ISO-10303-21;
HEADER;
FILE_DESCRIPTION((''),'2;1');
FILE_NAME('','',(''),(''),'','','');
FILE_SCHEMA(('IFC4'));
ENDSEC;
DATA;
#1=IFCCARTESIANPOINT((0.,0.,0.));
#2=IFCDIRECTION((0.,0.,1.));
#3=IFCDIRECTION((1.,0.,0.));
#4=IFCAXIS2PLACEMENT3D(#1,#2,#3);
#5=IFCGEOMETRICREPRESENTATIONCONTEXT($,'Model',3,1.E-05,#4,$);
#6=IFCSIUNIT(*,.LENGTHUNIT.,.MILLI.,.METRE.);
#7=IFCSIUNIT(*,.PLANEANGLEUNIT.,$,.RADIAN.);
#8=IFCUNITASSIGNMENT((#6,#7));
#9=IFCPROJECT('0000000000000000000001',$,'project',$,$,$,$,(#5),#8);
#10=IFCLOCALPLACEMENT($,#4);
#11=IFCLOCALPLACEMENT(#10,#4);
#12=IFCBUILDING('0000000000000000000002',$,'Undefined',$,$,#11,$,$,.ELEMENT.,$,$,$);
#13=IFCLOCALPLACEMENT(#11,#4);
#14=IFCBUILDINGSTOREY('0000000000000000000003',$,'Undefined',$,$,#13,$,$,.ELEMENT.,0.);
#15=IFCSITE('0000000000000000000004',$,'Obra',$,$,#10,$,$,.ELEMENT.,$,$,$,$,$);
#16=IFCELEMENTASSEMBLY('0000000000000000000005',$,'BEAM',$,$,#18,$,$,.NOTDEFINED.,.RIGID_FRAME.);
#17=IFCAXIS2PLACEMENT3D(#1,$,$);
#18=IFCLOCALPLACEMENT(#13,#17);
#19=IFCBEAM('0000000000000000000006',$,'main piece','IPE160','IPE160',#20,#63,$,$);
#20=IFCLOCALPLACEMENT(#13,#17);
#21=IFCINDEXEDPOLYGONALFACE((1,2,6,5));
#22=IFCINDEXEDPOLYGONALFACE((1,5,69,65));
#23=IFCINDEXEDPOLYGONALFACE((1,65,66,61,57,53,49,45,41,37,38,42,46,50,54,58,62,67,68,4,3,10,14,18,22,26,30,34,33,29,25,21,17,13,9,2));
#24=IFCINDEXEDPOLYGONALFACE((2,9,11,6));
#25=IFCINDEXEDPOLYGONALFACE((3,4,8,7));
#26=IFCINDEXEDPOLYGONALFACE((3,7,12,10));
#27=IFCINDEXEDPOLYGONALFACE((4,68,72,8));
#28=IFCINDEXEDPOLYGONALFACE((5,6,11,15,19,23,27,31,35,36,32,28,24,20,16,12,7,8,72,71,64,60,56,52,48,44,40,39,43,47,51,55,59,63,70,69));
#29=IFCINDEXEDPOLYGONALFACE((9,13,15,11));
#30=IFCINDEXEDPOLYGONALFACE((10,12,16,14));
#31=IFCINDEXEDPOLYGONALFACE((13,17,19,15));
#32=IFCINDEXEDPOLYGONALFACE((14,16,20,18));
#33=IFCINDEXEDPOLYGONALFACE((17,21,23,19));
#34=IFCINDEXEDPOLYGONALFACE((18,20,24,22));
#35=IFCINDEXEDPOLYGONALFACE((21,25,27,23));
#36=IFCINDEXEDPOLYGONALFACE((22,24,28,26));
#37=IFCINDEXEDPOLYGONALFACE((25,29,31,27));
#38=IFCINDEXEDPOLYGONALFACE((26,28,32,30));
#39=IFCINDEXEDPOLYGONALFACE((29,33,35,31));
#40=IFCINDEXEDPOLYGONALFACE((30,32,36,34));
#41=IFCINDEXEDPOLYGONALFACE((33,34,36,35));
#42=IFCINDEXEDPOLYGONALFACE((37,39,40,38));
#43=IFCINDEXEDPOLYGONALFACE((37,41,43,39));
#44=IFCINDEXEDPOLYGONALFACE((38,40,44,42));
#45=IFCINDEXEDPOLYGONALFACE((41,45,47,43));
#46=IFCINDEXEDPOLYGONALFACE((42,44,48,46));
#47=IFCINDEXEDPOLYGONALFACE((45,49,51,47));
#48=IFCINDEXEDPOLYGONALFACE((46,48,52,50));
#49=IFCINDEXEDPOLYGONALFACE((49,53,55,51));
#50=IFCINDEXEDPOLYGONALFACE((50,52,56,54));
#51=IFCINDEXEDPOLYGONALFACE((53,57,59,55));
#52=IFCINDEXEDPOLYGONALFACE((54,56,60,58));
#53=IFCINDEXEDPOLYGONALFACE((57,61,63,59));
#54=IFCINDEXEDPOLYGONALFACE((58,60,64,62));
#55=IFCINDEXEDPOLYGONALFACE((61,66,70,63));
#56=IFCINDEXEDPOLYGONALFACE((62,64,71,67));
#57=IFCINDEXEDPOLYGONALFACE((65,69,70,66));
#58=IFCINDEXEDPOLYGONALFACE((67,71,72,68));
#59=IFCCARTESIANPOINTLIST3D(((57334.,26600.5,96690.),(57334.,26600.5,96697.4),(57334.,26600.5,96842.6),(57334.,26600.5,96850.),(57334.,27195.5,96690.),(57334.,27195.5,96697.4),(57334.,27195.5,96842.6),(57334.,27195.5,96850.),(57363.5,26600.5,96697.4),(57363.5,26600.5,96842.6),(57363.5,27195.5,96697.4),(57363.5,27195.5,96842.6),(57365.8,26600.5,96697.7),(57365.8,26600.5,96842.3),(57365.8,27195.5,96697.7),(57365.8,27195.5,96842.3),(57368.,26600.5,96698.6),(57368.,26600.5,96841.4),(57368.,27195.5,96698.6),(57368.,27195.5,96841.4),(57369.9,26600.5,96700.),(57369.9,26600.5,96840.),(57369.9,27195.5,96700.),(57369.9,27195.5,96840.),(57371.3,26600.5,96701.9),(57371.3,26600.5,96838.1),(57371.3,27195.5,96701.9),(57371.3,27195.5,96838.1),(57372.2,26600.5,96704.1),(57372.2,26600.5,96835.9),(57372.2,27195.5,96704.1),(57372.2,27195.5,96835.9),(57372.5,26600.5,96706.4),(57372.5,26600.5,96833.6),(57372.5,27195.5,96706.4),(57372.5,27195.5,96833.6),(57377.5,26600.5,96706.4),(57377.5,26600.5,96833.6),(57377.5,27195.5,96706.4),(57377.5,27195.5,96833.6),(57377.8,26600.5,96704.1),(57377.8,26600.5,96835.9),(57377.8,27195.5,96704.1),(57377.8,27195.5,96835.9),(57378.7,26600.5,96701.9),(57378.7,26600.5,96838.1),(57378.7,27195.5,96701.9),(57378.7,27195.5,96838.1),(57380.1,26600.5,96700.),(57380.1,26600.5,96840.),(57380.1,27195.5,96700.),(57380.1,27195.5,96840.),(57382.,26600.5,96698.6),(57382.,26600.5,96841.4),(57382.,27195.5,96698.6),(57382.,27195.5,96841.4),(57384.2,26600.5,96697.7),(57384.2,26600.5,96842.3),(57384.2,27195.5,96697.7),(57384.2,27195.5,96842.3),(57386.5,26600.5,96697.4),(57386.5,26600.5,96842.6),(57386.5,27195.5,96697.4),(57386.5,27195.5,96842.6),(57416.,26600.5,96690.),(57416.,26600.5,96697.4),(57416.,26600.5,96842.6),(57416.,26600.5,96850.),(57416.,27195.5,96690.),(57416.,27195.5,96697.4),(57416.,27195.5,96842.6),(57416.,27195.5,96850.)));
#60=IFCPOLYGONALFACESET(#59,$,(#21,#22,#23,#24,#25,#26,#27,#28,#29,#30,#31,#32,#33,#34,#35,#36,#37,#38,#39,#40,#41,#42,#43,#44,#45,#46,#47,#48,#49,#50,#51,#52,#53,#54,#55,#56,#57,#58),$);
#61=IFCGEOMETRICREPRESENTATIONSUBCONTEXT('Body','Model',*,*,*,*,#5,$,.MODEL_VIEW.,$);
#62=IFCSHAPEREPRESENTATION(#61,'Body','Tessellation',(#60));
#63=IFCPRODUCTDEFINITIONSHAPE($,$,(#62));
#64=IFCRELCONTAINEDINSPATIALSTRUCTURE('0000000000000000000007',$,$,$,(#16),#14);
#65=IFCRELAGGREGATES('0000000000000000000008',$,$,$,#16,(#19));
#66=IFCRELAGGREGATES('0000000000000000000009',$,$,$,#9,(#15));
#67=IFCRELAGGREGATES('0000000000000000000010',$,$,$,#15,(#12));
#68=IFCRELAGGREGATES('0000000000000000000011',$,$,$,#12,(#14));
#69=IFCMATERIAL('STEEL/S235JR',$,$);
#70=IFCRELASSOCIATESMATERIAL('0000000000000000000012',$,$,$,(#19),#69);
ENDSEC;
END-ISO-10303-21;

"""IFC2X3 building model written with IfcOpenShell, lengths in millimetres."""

from ifc_helpers import new_model, si_unit, frame, origin_with_axes, origin_2d_with_axis, place, context, subcontext, project, spatial, i_section, extrude, material, element, aggregate, save


model = new_model("IFC2X3")

# Units and contexts
model_context = context("Model", 3, precision=1e-05, world=origin_with_axes())
body_context = subcontext(model_context, "Body", "Model", "MODEL_VIEW")
ifc_project = project(units=[si_unit("LENGTHUNIT", "METRE", prefix="MILLI"), si_unit("PLANEANGLEUNIT", "RADIAN")], contexts=[model_context])

# Site, building, storey
site_placement = place(None, origin_with_axes())
site = spatial("IfcSite", under=ifc_project, at=site_placement, Name="Obra", CompositionType="ELEMENT")
building_placement = place(site_placement, origin_with_axes())
building = spatial("IfcBuilding", under=site, at=building_placement, Name="Undefined", CompositionType="ELEMENT")
storey_placement = place(building_placement, origin_with_axes())
storey = spatial("IfcBuildingStorey", under=building, at=storey_placement, Name="Undefined", CompositionType="ELEMENT", Elevation=0.0)

# Element assembly, beam
ifc_material_1 = material(Name="STEEL/S235JR")
assembly_1_placement = place(storey_placement, origin_with_axes())
assembly_1 = element("IfcElementAssembly", 1, at=assembly_1_placement, inside=storey, Name="BEAM", AssemblyPlace="NOTDEFINED", PredefinedType="RIGID_FRAME")
beam_1_placement = place(assembly_1_placement, frame((57375.0, 27195.5, 96770.0), z_axis=(0.0, 0.0, 1.0), x_axis=(0.0, -1.0, 0.0)))
beam_1 = element("IfcBeam", 2, at=beam_1_placement, material=ifc_material_1, Name="main piece", Description="IPE160", ObjectType="IPE160", context=body_context, shape_type="SweptSolid", body=[
    extrude(i_section(OverallWidth=82.0, OverallDepth=160.0, WebThickness=5.0, FlangeThickness=7.4, FilletRadius=9.0, at=origin_2d_with_axis()), frame((595.0, 0.0, 0.0), z_axis=(-1.0, 0.0, 0.0), x_axis=(0.0, -1.0, 0.0)), (0.0, 0.0, 1.0), 595.0),
])
aggregate(assembly_1, [beam_1])

save(model, "model.ifc")
